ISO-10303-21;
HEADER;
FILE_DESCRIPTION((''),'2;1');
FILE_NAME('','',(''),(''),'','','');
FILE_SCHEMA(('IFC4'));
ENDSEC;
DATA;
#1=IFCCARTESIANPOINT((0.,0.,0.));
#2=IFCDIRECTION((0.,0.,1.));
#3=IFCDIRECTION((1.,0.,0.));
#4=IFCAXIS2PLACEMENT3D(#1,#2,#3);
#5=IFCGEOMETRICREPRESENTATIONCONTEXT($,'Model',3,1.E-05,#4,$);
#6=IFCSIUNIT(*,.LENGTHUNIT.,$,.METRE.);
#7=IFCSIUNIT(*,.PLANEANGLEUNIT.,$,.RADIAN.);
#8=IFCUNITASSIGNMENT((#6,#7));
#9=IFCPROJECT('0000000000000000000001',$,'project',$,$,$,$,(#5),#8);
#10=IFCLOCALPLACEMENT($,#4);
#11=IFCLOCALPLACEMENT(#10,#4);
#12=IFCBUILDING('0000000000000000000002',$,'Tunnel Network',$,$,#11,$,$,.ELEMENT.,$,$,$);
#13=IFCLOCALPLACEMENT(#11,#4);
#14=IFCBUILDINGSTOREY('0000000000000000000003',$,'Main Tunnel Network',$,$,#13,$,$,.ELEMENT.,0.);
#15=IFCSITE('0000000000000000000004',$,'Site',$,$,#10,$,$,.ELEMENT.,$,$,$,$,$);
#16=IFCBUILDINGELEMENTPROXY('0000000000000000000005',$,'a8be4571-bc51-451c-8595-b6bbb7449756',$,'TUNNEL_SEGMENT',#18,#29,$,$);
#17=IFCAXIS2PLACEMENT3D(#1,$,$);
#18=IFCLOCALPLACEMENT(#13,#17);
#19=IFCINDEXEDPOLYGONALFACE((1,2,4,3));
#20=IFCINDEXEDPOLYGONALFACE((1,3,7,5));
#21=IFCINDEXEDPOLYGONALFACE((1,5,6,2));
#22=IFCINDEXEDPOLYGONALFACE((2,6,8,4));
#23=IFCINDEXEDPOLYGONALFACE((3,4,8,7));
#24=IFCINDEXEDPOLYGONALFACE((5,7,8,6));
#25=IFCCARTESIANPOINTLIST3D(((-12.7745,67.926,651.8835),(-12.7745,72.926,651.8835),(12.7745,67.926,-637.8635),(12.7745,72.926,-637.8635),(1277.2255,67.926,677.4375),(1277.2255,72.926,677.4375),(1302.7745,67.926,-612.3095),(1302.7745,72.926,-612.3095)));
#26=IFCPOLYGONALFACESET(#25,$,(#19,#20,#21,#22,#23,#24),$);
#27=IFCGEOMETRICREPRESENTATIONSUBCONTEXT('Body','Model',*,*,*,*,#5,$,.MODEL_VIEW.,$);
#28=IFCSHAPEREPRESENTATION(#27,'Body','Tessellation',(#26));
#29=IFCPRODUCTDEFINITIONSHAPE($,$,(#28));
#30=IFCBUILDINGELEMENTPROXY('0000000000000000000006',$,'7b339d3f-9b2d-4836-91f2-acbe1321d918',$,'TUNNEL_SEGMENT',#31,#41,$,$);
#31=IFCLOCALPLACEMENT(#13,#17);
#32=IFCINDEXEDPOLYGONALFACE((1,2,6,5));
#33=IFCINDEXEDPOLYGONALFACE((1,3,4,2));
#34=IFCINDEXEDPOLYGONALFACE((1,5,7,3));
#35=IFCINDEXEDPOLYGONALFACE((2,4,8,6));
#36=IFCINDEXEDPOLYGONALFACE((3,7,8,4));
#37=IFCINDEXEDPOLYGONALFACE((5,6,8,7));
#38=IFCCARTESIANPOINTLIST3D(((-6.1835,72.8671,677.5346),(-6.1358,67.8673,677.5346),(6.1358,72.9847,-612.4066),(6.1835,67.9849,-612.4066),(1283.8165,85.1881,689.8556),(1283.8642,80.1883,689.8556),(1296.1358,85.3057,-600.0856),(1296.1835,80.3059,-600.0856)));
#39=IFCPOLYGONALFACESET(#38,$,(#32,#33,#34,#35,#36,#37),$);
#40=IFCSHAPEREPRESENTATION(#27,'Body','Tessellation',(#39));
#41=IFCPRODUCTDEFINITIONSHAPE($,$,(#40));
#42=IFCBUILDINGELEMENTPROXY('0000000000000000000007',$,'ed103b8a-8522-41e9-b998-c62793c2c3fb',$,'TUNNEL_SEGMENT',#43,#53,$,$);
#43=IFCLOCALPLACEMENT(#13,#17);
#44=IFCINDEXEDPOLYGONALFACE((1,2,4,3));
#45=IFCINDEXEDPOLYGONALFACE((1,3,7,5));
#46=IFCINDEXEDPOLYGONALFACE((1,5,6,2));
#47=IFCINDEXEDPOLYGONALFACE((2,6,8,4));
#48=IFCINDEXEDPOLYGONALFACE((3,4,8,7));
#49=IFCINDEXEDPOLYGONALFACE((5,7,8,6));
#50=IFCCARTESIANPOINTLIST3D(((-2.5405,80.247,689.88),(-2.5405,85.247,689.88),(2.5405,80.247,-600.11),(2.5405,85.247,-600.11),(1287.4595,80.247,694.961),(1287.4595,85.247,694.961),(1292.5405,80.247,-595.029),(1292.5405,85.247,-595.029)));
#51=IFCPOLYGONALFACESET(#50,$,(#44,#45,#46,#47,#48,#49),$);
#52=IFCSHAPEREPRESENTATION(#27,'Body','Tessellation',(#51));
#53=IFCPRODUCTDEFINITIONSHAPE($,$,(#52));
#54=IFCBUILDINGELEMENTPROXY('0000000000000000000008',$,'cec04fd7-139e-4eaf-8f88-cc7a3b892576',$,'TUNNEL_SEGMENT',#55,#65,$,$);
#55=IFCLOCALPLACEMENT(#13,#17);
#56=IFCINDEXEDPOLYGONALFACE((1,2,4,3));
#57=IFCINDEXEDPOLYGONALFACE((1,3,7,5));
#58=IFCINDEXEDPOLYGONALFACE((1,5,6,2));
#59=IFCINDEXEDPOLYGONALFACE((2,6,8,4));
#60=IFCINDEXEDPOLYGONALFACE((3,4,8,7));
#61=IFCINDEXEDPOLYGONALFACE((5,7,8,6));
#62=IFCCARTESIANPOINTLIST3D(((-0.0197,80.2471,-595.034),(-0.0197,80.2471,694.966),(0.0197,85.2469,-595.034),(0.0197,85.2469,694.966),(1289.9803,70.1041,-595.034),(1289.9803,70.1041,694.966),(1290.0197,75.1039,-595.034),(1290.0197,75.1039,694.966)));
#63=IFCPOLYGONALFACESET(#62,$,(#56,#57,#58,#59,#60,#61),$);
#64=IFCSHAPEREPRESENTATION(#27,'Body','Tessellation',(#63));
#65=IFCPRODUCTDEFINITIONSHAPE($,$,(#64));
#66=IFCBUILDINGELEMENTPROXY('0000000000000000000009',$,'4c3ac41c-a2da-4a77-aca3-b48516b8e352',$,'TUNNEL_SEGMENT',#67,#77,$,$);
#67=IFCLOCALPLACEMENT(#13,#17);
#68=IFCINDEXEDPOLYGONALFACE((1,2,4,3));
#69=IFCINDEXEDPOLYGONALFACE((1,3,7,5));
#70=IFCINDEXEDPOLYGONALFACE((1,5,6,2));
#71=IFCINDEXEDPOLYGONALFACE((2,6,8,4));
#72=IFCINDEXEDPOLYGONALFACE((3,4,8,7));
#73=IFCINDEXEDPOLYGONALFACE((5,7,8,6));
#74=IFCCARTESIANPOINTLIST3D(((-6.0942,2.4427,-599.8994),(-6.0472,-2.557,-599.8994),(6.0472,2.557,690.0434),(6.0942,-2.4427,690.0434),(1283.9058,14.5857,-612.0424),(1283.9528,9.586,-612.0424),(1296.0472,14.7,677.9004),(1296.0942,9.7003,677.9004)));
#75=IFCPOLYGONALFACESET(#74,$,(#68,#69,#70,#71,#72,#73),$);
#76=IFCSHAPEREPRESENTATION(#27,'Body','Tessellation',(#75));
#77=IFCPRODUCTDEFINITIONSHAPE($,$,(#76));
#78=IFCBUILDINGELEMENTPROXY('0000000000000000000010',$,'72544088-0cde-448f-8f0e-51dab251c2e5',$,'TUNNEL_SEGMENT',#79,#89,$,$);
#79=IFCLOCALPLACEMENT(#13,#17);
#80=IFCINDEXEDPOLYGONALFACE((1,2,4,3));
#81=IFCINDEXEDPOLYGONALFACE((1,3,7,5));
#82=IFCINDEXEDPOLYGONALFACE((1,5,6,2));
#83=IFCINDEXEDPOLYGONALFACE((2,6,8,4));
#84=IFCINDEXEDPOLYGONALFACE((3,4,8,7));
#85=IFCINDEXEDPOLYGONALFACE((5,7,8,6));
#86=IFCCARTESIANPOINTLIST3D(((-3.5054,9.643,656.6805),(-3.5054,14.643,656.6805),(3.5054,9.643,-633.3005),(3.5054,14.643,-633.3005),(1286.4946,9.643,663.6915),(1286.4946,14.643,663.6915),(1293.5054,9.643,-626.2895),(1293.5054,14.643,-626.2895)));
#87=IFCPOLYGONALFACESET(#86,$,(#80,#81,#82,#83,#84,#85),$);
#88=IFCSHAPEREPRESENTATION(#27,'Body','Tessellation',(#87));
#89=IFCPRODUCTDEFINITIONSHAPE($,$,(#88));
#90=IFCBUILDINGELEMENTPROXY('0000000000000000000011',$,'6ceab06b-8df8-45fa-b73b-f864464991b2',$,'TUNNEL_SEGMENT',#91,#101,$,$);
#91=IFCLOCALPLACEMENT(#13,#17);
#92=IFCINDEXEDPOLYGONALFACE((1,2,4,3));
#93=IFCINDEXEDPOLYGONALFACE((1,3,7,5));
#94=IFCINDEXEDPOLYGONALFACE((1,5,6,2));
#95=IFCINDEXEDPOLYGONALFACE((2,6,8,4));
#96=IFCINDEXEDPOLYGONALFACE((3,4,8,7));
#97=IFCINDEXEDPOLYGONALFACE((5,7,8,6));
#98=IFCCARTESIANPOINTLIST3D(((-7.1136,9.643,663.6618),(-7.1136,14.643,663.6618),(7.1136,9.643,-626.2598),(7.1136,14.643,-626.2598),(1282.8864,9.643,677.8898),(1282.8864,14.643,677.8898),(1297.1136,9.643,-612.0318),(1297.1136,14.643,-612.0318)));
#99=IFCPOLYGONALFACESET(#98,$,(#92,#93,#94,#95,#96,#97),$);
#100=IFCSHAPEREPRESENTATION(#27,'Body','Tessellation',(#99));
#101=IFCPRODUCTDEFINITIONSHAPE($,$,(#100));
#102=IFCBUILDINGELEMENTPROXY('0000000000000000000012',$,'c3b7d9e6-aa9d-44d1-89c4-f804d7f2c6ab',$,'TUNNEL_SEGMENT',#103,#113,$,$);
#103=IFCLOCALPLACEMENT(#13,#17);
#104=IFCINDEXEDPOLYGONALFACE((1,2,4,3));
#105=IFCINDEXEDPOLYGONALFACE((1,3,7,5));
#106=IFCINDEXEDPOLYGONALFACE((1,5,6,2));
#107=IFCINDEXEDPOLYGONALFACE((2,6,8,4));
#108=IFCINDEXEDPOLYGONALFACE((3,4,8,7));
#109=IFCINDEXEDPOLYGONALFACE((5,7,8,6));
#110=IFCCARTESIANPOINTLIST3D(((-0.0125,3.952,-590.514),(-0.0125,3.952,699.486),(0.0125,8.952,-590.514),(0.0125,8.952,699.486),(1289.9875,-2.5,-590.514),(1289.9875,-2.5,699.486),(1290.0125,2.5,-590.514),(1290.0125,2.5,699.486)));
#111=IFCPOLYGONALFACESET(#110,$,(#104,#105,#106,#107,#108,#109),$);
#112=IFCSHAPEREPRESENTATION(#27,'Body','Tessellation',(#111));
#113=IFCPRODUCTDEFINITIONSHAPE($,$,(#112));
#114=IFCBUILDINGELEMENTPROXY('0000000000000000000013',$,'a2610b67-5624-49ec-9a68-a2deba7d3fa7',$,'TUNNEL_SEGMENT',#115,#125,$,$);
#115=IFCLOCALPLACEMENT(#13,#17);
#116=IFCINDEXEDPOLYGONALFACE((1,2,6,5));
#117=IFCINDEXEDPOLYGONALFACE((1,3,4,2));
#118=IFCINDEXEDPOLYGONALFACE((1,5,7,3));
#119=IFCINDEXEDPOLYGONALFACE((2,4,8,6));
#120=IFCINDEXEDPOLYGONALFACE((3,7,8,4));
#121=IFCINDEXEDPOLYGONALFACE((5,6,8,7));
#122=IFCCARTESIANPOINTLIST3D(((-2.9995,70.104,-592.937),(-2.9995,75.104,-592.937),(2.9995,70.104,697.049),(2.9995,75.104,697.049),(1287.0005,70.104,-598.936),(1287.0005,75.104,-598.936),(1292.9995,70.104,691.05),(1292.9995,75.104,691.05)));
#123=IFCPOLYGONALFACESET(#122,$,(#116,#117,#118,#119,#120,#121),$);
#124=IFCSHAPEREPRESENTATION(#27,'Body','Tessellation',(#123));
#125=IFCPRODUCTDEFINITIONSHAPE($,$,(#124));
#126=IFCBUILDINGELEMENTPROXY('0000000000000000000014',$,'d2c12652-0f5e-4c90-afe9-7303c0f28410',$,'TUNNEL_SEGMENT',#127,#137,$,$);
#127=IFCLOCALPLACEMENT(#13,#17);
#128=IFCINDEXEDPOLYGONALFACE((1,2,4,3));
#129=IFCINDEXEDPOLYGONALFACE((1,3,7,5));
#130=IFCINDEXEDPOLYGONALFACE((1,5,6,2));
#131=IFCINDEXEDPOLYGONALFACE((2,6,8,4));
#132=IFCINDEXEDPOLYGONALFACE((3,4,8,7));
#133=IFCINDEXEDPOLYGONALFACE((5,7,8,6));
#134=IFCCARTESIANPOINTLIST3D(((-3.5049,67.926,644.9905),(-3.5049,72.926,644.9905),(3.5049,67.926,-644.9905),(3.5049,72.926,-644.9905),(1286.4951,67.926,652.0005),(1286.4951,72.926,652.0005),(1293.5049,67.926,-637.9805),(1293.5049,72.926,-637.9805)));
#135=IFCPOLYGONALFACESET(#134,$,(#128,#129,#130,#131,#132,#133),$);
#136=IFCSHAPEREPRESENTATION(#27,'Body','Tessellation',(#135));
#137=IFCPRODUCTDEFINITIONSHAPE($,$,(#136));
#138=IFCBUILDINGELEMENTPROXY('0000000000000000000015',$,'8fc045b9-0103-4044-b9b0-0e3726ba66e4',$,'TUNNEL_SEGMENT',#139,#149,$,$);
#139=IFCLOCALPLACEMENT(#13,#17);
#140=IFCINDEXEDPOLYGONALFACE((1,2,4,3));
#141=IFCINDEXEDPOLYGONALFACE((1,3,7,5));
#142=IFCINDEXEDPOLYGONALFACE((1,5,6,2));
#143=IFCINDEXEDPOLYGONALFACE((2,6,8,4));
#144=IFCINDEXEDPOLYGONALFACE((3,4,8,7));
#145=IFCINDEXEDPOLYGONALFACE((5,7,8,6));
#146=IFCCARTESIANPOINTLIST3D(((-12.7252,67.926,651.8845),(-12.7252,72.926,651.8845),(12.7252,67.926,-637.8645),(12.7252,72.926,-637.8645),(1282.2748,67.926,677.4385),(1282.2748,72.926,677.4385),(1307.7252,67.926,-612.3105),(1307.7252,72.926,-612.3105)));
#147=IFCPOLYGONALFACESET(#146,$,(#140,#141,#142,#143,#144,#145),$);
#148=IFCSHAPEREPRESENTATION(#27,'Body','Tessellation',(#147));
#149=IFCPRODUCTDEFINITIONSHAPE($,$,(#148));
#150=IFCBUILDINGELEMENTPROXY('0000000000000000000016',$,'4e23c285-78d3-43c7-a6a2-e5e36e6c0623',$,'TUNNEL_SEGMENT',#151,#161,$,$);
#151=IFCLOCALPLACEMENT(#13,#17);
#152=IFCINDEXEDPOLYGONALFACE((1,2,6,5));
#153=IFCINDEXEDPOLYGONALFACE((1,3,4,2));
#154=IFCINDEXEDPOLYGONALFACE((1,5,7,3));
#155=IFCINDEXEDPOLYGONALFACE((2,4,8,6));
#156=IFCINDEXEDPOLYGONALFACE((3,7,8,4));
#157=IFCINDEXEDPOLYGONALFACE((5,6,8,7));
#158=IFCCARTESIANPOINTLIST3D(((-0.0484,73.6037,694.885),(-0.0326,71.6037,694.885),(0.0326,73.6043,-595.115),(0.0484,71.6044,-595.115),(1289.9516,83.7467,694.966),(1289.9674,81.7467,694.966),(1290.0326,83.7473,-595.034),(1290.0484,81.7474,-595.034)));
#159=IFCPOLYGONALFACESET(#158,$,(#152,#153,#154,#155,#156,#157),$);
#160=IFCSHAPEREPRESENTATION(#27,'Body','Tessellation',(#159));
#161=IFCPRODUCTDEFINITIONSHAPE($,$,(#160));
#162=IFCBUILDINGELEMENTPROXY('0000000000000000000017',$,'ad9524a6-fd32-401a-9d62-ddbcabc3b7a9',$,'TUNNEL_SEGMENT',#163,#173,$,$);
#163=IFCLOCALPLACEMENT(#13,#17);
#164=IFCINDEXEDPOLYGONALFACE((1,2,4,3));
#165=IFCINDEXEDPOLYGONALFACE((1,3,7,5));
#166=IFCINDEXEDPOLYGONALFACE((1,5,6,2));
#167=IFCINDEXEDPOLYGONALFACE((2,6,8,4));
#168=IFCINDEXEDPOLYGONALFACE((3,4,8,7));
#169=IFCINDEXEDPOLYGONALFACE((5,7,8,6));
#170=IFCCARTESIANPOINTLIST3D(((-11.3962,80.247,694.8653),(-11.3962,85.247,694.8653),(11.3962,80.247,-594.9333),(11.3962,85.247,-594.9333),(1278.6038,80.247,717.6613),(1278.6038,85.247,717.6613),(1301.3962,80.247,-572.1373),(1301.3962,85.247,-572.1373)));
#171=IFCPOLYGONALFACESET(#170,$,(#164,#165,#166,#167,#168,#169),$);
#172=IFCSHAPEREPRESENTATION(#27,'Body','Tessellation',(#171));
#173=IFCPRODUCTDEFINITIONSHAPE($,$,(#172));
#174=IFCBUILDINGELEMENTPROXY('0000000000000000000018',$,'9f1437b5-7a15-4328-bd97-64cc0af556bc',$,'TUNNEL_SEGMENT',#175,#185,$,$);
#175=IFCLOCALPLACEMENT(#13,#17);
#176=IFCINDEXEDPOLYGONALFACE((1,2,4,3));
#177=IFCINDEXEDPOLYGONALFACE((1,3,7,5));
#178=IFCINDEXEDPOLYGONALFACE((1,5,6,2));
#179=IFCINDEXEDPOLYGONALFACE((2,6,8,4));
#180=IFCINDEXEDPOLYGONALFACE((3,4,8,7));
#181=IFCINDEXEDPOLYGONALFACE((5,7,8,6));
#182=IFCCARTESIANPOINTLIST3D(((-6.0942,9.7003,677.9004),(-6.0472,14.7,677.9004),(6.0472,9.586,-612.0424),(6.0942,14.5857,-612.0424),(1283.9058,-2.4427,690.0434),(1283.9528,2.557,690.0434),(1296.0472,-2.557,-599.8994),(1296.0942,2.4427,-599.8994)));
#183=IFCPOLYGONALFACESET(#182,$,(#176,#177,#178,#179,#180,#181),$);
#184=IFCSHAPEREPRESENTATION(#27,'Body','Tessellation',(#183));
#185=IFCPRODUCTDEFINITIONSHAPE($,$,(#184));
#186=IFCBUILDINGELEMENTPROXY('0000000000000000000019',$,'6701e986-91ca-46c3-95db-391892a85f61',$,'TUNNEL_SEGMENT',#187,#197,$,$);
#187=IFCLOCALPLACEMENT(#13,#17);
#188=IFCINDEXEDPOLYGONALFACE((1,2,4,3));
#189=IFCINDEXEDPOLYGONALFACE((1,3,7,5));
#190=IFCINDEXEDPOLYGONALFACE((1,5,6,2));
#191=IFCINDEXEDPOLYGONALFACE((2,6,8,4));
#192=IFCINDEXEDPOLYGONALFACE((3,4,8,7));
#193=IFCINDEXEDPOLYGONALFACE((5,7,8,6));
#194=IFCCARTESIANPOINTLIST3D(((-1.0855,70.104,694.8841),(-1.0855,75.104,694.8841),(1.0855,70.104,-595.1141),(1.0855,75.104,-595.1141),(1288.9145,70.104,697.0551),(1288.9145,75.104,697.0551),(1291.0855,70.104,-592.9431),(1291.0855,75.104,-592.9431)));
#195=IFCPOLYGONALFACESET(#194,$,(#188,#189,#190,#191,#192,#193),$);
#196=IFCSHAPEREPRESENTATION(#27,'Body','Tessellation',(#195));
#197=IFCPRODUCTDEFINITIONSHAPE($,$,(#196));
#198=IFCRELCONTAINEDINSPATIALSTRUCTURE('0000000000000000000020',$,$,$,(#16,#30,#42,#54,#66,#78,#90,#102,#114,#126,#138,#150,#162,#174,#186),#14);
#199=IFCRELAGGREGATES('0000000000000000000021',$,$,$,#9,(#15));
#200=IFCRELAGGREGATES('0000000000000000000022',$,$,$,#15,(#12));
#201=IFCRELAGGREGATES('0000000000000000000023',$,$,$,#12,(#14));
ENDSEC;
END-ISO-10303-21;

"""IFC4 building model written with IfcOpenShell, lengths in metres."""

from ifc_helpers import new_model, si_unit, frame, origin_with_axes, origin_2d_with_axis, place, context, subcontext, project, spatial, rectangle, extrude, element, save


model = new_model("IFC4")

# Units and contexts
model_context = context("Model", 3, precision=1e-05, world=origin_with_axes())
body_context = subcontext(model_context, "Body", "Model", "MODEL_VIEW")
ifc_project = project(units=[si_unit("LENGTHUNIT", "METRE"), si_unit("PLANEANGLEUNIT", "RADIAN")], contexts=[model_context])

# Site, building, storey
site_placement = place(None, origin_with_axes())
site = spatial("IfcSite", under=ifc_project, at=site_placement, Name="Site", CompositionType="ELEMENT")
building_placement = place(site_placement, origin_with_axes())
building = spatial("IfcBuilding", under=site, at=building_placement, Name="Tunnel Network", CompositionType="ELEMENT")
storey_placement = place(building_placement, origin_with_axes())
storey = spatial("IfcBuildingStorey", under=building, at=storey_placement, Name="Main Tunnel Network", CompositionType="ELEMENT", Elevation=0.0)

# Building element proxies
proxy_1_placement = place(storey_placement, frame((0.0, 70.426, 7.01), z_axis=(0.999804, 0.0, 0.019805), x_axis=(-0.019805, 0.0, 0.999804)))
element("IfcBuildingElementProxy", 1, at=proxy_1_placement, inside=storey, Name="a8be4571-bc51-451c-8595-b6bbb7449756", ObjectType="TUNNEL_SEGMENT", context=body_context, shape_type="SweptSolid", body=[
    extrude(rectangle(XDim=1290.0, YDim=5.0, at=origin_2d_with_axis()), origin_with_axes(), (0.0, 0.0, 1.0), 1290.2531),
])
proxy_2_placement = place(storey_placement, frame((0.0, 70.426, 32.564), z_axis=(0.999909, 0.00955, 0.00955), x_axis=(-0.00955, -0.000091, 0.999954)))
element("IfcBuildingElementProxy", 2, at=proxy_2_placement, inside=storey, Name="7b339d3f-9b2d-4836-91f2-acbe1321d918", ObjectType="TUNNEL_SEGMENT", context=body_context, shape_type="SweptSolid", body=[
    extrude(rectangle(XDim=1290.0, YDim=5.0, at=origin_2d_with_axis()), origin_with_axes(), (0.0, 0.0, 1.0), 1290.1177),
])
proxy_3_placement = place(storey_placement, frame((0.0, 82.747, 44.885), z_axis=(0.999992, 0.0, 0.003939), x_axis=(-0.003939, 0.0, 0.999992)))
element("IfcBuildingElementProxy", 3, at=proxy_3_placement, inside=storey, Name="ed103b8a-8522-41e9-b998-c62793c2c3fb", ObjectType="TUNNEL_SEGMENT", context=body_context, shape_type="SweptSolid", body=[
    extrude(rectangle(XDim=1290.0, YDim=5.0, at=origin_2d_with_axis()), origin_with_axes(), (0.0, 0.0, 1.0), 1290.01),
])
proxy_4_placement = place(storey_placement, frame((0.0, 82.747, 49.966), z_axis=(0.999969, -0.007863, 0.0), x_axis=(0.0, 0.0, 1.0)))
element("IfcBuildingElementProxy", 4, at=proxy_4_placement, inside=storey, Name="cec04fd7-139e-4eaf-8f88-cc7a3b892576", ObjectType="TUNNEL_SEGMENT", context=body_context, shape_type="SweptSolid", body=[
    extrude(rectangle(XDim=1290.0, YDim=5.0, at=origin_2d_with_axis()), origin_with_axes(), (0.0, 0.0, 1.0), 1290.0399),
])
proxy_5_placement = place(storey_placement, frame((0.0, 0.0, 45.072), z_axis=(0.999911, 0.009412, -0.009412), x_axis=(0.009412, 0.000089, 0.999956)))
element("IfcBuildingElementProxy", 5, at=proxy_5_placement, inside=storey, Name="4c3ac41c-a2da-4a77-aca3-b48516b8e352", ObjectType="TUNNEL_SEGMENT", context=body_context, shape_type="SweptSolid", body=[
    extrude(rectangle(XDim=1290.0, YDim=5.0, at=origin_2d_with_axis()), origin_with_axes(), (0.0, 0.0, 1.0), 1290.1143),
])
proxy_6_placement = place(storey_placement, frame((0.0, 12.143, 11.69), z_axis=(0.999985, 0.0, 0.005435), x_axis=(-0.005435, 0.0, 0.999985)))
element("IfcBuildingElementProxy", 6, at=proxy_6_placement, inside=storey, Name="72544088-0cde-448f-8f0e-51dab251c2e5", ObjectType="TUNNEL_SEGMENT", context=body_context, shape_type="SweptSolid", body=[
    extrude(rectangle(XDim=1290.0, YDim=5.0, at=origin_2d_with_axis()), origin_with_axes(), (0.0, 0.0, 1.0), 1290.0191),
])
proxy_7_placement = place(storey_placement, frame((0.0, 12.143, 18.701), z_axis=(0.999939, 0.0, 0.011029), x_axis=(-0.011029, 0.0, 0.999939)))
element("IfcBuildingElementProxy", 7, at=proxy_7_placement, inside=storey, Name="6ceab06b-8df8-45fa-b73b-f864464991b2", ObjectType="TUNNEL_SEGMENT", context=body_context, shape_type="SweptSolid", body=[
    extrude(rectangle(XDim=1290.0, YDim=5.0, at=origin_2d_with_axis()), origin_with_axes(), (0.0, 0.0, 1.0), 1290.0785),
])
proxy_8_placement = place(storey_placement, frame((0.0, 6.452, 54.486), z_axis=(0.999987, -0.005001, 0.0), x_axis=(0.0, 0.0, 1.0)))
element("IfcBuildingElementProxy", 8, at=proxy_8_placement, inside=storey, Name="c3b7d9e6-aa9d-44d1-89c4-f804d7f2c6ab", ObjectType="TUNNEL_SEGMENT", context=body_context, shape_type="SweptSolid", body=[
    extrude(rectangle(XDim=1290.0, YDim=5.0, at=origin_2d_with_axis()), origin_with_axes(), (0.0, 0.0, 1.0), 1290.0161),
])
proxy_9_placement = place(storey_placement, frame((0.0, 72.604, 52.056), z_axis=(0.999989, 0.0, -0.00465), x_axis=(0.00465, 0.0, 0.999989)))
element("IfcBuildingElementProxy", 9, at=proxy_9_placement, inside=storey, Name="a2610b67-5624-49ec-9a68-a2deba7d3fa7", ObjectType="TUNNEL_SEGMENT", context=body_context, shape_type="SweptSolid", body=[
    extrude(rectangle(XDim=1290.0, YDim=5.0, at=origin_2d_with_axis()), origin_with_axes(), (0.0, 0.0, 1.0), 1290.0139),
])
proxy_10_placement = place(storey_placement, frame((0.0, 70.426, 0.0), z_axis=(0.999985, 0.0, 0.005434), x_axis=(-0.005434, 0.0, 0.999985)))
element("IfcBuildingElementProxy", 10, at=proxy_10_placement, inside=storey, Name="d2c12652-0f5e-4c90-afe9-7303c0f28410", ObjectType="TUNNEL_SEGMENT", context=body_context, shape_type="SweptSolid", body=[
    extrude(rectangle(XDim=1290.0, YDim=5.0, at=origin_2d_with_axis()), origin_with_axes(), (0.0, 0.0, 1.0), 1290.019),
])
proxy_11_placement = place(storey_placement, frame((0.0, 70.426, 7.01), z_axis=(0.999805, 0.0, 0.019729), x_axis=(-0.019729, 0.0, 0.999805)))
element("IfcBuildingElementProxy", 11, at=proxy_11_placement, inside=storey, Name="8fc045b9-0103-4044-b9b0-0e3726ba66e4", ObjectType="TUNNEL_SEGMENT", context=body_context, shape_type="SweptSolid", body=[
    extrude(rectangle(XDim=1290.0, YDim=5.0, at=origin_2d_with_axis()), origin_with_axes(), (0.0, 0.0, 1.0), 1295.2521),
])
proxy_12_placement = place(storey_placement, frame((0.0, 72.604, 49.885), z_axis=(0.999969, 0.007863, 0.000063), x_axis=(-0.000063, 0.0, 1.0)))
element("IfcBuildingElementProxy", 12, at=proxy_12_placement, inside=storey, Name="4e23c285-78d3-43c7-a6a2-e5e36e6c0623", ObjectType="TUNNEL_SEGMENT", context=body_context, shape_type="SweptSolid", body=[
    extrude(rectangle(XDim=1290.0, YDim=2.0, at=origin_2d_with_axis()), origin_with_axes(), (0.0, 0.0, 1.0), 1290.0399),
])
proxy_13_placement = place(storey_placement, frame((0.0, 82.747, 49.966), z_axis=(0.999844, 0.0, 0.017669), x_axis=(-0.017669, 0.0, 0.999844)))
element("IfcBuildingElementProxy", 13, at=proxy_13_placement, inside=storey, Name="ad9524a6-fd32-401a-9d62-ddbcabc3b7a9", ObjectType="TUNNEL_SEGMENT", context=body_context, shape_type="SweptSolid", body=[
    extrude(rectangle(XDim=1290.0, YDim=5.0, at=origin_2d_with_axis()), origin_with_axes(), (0.0, 0.0, 1.0), 1290.2014),
])
proxy_14_placement = place(storey_placement, frame((0.0, 12.143, 32.929), z_axis=(0.999911, -0.009412, 0.009412), x_axis=(-0.009412, 0.000089, 0.999956)))
element("IfcBuildingElementProxy", 14, at=proxy_14_placement, inside=storey, Name="9f1437b5-7a15-4328-bd97-64cc0af556bc", ObjectType="TUNNEL_SEGMENT", context=body_context, shape_type="SweptSolid", body=[
    extrude(rectangle(XDim=1290.0, YDim=5.0, at=origin_2d_with_axis()), origin_with_axes(), (0.0, 0.0, 1.0), 1290.1143),
])
proxy_15_placement = place(storey_placement, frame((0.0, 72.604, 49.885), z_axis=(0.999999, 0.0, 0.001683), x_axis=(-0.001683, 0.0, 0.999999)))
element("IfcBuildingElementProxy", 15, at=proxy_15_placement, inside=storey, Name="6701e986-91ca-46c3-95db-391892a85f61", ObjectType="TUNNEL_SEGMENT", context=body_context, shape_type="SweptSolid", body=[
    extrude(rectangle(XDim=1290.0, YDim=5.0, at=origin_2d_with_axis()), origin_with_axes(), (0.0, 0.0, 1.0), 1290.0018),
])

save(model, "model.ifc")
